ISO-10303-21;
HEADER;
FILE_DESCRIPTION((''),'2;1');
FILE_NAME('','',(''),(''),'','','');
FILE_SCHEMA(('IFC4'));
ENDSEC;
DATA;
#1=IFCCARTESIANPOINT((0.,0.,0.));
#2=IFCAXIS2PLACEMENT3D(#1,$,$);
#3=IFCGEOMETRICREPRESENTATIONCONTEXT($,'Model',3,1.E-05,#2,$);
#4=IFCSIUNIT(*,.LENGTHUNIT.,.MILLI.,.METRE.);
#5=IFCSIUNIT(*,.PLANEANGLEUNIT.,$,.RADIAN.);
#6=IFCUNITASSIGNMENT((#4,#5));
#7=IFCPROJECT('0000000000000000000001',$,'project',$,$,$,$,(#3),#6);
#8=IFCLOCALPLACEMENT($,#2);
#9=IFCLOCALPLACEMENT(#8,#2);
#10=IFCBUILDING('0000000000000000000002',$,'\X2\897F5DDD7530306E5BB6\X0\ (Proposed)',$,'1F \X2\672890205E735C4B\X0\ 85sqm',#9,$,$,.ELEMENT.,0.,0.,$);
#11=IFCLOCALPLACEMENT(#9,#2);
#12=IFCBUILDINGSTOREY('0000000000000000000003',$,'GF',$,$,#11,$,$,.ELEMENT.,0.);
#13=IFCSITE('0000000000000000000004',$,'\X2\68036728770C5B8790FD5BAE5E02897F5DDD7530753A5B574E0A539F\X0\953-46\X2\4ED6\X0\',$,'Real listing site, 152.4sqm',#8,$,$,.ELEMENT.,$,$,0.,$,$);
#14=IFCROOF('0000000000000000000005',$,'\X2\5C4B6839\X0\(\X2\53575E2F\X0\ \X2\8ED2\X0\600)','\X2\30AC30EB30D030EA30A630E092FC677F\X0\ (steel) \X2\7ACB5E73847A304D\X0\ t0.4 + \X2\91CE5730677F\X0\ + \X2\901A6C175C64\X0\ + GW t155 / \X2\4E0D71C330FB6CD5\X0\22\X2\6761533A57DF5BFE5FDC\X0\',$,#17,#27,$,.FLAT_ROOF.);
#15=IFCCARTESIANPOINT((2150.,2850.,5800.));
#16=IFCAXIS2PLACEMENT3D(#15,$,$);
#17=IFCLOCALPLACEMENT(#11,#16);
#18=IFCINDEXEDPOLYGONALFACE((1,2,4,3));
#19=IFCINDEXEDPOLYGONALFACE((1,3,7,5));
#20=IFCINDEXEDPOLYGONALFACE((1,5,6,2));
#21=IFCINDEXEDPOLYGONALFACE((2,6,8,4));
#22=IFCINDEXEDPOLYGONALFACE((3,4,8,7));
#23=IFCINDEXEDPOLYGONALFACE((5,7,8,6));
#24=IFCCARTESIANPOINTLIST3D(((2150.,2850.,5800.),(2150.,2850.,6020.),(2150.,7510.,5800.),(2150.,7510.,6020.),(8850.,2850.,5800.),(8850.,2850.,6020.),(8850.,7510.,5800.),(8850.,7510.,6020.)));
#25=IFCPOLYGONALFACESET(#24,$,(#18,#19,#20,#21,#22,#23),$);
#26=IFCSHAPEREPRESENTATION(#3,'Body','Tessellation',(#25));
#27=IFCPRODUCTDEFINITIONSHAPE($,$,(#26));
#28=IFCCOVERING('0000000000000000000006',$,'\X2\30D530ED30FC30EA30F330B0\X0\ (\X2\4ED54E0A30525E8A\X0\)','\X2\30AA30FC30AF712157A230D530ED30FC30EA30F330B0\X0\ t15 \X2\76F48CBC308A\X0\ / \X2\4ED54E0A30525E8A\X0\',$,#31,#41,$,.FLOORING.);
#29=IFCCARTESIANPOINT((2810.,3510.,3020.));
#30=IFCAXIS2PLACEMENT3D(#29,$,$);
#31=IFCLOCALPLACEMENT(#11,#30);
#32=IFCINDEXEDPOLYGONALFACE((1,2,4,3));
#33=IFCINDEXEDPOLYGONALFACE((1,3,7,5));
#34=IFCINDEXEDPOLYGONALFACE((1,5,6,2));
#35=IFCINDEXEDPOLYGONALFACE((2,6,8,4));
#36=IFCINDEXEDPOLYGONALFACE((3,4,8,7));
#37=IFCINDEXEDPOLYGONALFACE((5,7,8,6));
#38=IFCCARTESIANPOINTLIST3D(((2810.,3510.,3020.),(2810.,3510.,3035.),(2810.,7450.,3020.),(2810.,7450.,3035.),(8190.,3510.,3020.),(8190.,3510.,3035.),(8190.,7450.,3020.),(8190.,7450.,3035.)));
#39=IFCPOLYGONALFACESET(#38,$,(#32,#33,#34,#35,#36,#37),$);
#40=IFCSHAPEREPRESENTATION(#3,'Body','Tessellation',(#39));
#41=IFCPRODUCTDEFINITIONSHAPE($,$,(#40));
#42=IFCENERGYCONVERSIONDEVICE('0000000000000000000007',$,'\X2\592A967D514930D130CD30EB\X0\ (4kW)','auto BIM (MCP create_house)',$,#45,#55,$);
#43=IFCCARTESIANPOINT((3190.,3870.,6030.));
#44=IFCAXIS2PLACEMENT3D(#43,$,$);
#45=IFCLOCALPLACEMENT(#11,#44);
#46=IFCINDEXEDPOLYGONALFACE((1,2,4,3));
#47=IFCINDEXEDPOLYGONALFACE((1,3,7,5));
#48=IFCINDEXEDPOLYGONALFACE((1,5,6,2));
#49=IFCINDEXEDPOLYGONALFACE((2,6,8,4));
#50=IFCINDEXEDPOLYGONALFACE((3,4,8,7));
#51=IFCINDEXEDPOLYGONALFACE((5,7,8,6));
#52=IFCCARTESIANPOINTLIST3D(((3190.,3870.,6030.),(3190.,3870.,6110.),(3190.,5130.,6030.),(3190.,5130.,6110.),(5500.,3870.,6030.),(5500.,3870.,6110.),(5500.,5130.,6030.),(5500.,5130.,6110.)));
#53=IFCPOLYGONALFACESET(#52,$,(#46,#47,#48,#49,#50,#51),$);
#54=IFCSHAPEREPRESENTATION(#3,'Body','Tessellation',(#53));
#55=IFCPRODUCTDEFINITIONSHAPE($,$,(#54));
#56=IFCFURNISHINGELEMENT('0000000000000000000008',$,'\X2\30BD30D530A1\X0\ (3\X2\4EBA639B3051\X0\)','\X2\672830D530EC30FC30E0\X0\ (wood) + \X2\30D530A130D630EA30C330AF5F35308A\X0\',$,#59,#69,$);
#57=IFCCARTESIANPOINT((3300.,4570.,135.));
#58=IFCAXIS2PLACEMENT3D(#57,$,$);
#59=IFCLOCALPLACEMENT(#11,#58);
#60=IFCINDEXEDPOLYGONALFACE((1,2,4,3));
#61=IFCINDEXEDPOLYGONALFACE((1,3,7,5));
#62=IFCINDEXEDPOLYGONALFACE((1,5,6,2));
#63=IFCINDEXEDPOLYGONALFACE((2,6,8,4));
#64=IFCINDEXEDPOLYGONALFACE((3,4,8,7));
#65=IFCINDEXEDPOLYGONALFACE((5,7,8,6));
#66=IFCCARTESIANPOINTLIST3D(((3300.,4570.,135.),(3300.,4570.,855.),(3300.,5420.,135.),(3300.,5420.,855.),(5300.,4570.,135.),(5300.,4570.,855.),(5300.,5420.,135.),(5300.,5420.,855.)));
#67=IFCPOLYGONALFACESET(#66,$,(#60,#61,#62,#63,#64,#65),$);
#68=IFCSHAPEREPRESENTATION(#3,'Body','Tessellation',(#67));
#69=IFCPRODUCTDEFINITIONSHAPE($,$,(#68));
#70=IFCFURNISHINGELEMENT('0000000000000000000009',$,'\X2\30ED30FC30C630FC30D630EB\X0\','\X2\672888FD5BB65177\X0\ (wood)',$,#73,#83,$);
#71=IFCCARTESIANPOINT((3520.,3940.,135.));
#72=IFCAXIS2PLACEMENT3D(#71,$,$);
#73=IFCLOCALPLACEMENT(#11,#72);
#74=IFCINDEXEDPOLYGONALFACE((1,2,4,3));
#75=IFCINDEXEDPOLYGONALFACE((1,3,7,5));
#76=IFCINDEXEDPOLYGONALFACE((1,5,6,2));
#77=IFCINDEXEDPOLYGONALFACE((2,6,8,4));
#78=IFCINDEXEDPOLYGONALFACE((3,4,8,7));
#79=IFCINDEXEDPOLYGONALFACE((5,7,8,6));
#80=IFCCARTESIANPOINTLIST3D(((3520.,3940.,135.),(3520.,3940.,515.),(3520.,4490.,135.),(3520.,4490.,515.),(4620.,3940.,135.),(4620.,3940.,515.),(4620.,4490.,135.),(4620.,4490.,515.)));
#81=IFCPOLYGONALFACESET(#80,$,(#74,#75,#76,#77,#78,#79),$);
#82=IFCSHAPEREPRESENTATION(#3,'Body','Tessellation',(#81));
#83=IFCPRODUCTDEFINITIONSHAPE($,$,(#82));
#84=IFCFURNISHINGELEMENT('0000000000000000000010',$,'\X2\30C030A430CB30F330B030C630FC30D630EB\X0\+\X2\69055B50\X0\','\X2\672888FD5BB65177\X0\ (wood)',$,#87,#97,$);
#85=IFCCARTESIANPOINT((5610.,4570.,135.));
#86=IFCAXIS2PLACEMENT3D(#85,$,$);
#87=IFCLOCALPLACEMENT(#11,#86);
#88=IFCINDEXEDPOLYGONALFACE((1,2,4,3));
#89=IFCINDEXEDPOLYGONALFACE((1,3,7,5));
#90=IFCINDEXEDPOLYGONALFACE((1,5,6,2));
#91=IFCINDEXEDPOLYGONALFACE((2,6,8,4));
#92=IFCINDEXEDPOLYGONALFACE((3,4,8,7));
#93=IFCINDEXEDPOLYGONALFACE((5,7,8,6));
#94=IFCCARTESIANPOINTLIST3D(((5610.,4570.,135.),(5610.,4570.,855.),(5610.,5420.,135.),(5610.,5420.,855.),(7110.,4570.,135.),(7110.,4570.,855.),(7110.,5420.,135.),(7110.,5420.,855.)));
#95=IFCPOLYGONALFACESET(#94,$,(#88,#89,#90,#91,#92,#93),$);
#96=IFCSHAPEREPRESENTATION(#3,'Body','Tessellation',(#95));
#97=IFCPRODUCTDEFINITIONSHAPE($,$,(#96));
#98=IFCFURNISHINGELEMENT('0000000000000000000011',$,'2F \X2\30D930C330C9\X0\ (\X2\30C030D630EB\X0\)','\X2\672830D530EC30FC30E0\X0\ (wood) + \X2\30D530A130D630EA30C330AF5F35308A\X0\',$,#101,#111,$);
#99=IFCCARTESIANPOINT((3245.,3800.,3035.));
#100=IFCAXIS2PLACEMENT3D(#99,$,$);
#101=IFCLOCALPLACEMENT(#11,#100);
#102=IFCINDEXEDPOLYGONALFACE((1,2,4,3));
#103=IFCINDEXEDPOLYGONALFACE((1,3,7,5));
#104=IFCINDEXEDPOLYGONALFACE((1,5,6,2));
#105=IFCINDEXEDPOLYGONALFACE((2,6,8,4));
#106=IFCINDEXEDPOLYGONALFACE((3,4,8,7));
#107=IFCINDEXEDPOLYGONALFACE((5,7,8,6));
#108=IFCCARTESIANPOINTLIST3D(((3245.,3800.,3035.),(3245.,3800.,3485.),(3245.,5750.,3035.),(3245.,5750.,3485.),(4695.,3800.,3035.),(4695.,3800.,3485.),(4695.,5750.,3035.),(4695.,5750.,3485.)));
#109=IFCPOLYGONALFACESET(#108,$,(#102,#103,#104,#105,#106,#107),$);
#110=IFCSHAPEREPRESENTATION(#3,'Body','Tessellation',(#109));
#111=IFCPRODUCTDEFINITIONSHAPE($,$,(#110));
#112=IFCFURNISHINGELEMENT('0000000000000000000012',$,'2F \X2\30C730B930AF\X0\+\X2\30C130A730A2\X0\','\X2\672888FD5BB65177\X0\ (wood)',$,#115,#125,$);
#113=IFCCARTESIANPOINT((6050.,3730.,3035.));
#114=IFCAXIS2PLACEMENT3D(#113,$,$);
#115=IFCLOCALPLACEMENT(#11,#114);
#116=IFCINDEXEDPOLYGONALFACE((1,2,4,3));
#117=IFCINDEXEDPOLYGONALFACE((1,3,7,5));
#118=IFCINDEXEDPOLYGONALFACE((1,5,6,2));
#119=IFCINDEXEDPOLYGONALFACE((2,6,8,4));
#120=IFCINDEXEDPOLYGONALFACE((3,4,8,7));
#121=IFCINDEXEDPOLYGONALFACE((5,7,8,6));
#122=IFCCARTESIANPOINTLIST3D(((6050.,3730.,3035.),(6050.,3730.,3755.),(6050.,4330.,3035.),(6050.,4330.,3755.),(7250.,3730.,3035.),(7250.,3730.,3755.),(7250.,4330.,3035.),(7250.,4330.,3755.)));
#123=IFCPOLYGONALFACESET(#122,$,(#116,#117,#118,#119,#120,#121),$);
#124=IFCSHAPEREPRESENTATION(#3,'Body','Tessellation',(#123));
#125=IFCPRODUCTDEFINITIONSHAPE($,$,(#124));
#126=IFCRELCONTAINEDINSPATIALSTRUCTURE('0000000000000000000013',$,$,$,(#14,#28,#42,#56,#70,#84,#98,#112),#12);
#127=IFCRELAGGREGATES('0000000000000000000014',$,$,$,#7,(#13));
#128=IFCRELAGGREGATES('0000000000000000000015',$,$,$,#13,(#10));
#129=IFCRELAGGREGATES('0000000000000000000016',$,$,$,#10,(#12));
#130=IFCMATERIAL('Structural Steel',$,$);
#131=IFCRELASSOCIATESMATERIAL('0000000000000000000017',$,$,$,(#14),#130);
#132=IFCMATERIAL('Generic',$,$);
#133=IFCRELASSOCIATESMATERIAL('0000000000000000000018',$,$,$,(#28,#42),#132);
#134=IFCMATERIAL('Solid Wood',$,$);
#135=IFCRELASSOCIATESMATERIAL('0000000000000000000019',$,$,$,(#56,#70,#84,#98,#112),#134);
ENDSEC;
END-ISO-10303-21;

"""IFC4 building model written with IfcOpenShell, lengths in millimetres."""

from ifc_helpers import new_model, si_unit, frame, frame_2d, origin, place, context, project, spatial, rectangle, extrude, material, element, save


model = new_model("IFC4")

# Units and contexts
model_context = context("Model", 3, precision=1e-05, world=origin())
ifc_project = project(units=[si_unit("LENGTHUNIT", "METRE", prefix="MILLI"), si_unit("PLANEANGLEUNIT", "RADIAN")], contexts=[model_context])

# Site, building, storey
site_placement = place(None, origin())
site = spatial("IfcSite", under=ifc_project, at=site_placement, Name="栃木県宇都宮市西川田町字上原953-46他", ObjectType="Real listing site, 152.4sqm", CompositionType="ELEMENT", RefElevation=0.0)
building_placement = place(site_placement, origin())
building = spatial("IfcBuilding", under=site, at=building_placement, Name="西川田の家 (Proposed)", ObjectType="1F 木造平屋 85sqm", CompositionType="ELEMENT", ElevationOfRefHeight=0.0, ElevationOfTerrain=0.0)
storey_placement = place(building_placement, origin())
storey = spatial("IfcBuildingStorey", under=building, at=storey_placement, Name="GF", CompositionType="ELEMENT", Elevation=0.0)

# Shared definitions
ifc_material_1 = material(Name="Solid Wood")

# Shared definitions
ifc_material_2 = material(Name="Generic")

# Roof
ifc_material_3 = material(Name="Structural Steel")
for number, where, name in (
    (1, (2150.0, 2850.0, 5800.0), "屋根(南帯 軒600)"),
):
    element("IfcRoof", number, at=place(storey_placement, frame(where)), inside=storey, material=ifc_material_3, Name=name, Description="ガルバリウム鋼板 (steel) 立平葺き t0.4 + 野地板 + 通気層 + GW t155 / 不燃・法22条区域対応", PredefinedType="FLAT_ROOF", context=model_context, shape_type="SweptSolid", body=[
        extrude(rectangle(XDim=6700.0, YDim=4660.0, at=frame_2d((3350.0, 2330.0))), frame((2150.0, 2850.0, 5800.0)), (0.0, 0.0, 1.0), 220.0),
    ])

# Covering
covering_placement = place(storey_placement, frame((2810.0, 3510.0, 3020.0)))
element("IfcCovering", 2, at=covering_placement, inside=storey, material=ifc_material_2, Name="フローリング (仕上げ床)", Description="オーク無垢フローリング t15 直貼り / 仕上げ床", PredefinedType="FLOORING", context=model_context, shape_type="SweptSolid", body=[
    extrude(rectangle(XDim=5380.0, YDim=3940.0, at=frame_2d((2690.0, 1970.0))), frame((2810.0, 3510.0, 3020.0)), (0.0, 0.0, 1.0), 15.0),
])

# Energy conversion device
energy_conversion_device_placement = place(storey_placement, frame((3190.0, 3870.0, 6030.0)))
element("IfcEnergyConversionDevice", 3, at=energy_conversion_device_placement, inside=storey, material=ifc_material_2, Name="太陽光パネル (4kW)", Description="auto BIM (MCP create_house)", context=model_context, shape_type="SweptSolid", body=[
    extrude(rectangle(XDim=2310.0, YDim=1260.0, at=frame_2d((1155.0, 630.0))), frame((3190.0, 3870.0, 6030.0)), (0.0, 0.0, 1.0), 80.0),
])

# Furnishing elements
furnishing_1_placement = place(storey_placement, frame((3300.0, 4570.0, 135.0)))
element("IfcFurnishingElement", 4, at=furnishing_1_placement, inside=storey, material=ifc_material_1, Name="ソファ (3人掛け)", Description="木フレーム (wood) + ファブリック張り", context=model_context, shape_type="SweptSolid", body=[
    extrude(rectangle(XDim=2000.0, YDim=850.0, at=frame_2d((1000.0, 425.0))), frame((3300.0, 4570.0, 135.0)), (0.0, 0.0, 1.0), 720.0),
])
furnishing_2_placement = place(storey_placement, frame((3520.0, 3940.0, 135.0)))
element("IfcFurnishingElement", 5, at=furnishing_2_placement, inside=storey, material=ifc_material_1, Name="ローテーブル", Description="木製家具 (wood)", context=model_context, shape_type="SweptSolid", body=[
    extrude(rectangle(XDim=1100.0, YDim=550.0, at=frame_2d((550.0, 275.0))), frame((3520.0, 3940.0, 135.0)), (0.0, 0.0, 1.0), 380.0),
])
furnishing_3_placement = place(storey_placement, frame((5610.0, 4570.0, 135.0)))
element("IfcFurnishingElement", 6, at=furnishing_3_placement, inside=storey, material=ifc_material_1, Name="ダイニングテーブル+椅子", Description="木製家具 (wood)", context=model_context, shape_type="SweptSolid", body=[
    extrude(rectangle(XDim=1500.0, YDim=850.0, at=frame_2d((750.0, 425.0))), frame((5610.0, 4570.0, 135.0)), (0.0, 0.0, 1.0), 720.0),
])
furnishing_4_placement = place(storey_placement, frame((3245.0, 3800.0, 3035.0)))
element("IfcFurnishingElement", 7, at=furnishing_4_placement, inside=storey, material=ifc_material_1, Name="2F ベッド (ダブル)", Description="木フレーム (wood) + ファブリック張り", context=model_context, shape_type="SweptSolid", body=[
    extrude(rectangle(XDim=1450.0, YDim=1950.0, at=frame_2d((725.0, 975.0))), frame((3245.0, 3800.0, 3035.0)), (0.0, 0.0, 1.0), 450.0),
])
furnishing_5_placement = place(storey_placement, frame((6050.0, 3730.0, 3035.0)))
element("IfcFurnishingElement", 8, at=furnishing_5_placement, inside=storey, material=ifc_material_1, Name="2F デスク+チェア", Description="木製家具 (wood)", context=model_context, shape_type="SweptSolid", body=[
    extrude(rectangle(XDim=1200.0, YDim=600.0, at=frame_2d((600.0, 300.0))), frame((6050.0, 3730.0, 3035.0)), (0.0, 0.0, 1.0), 720.0),
])

save(model, "model.ifc")
